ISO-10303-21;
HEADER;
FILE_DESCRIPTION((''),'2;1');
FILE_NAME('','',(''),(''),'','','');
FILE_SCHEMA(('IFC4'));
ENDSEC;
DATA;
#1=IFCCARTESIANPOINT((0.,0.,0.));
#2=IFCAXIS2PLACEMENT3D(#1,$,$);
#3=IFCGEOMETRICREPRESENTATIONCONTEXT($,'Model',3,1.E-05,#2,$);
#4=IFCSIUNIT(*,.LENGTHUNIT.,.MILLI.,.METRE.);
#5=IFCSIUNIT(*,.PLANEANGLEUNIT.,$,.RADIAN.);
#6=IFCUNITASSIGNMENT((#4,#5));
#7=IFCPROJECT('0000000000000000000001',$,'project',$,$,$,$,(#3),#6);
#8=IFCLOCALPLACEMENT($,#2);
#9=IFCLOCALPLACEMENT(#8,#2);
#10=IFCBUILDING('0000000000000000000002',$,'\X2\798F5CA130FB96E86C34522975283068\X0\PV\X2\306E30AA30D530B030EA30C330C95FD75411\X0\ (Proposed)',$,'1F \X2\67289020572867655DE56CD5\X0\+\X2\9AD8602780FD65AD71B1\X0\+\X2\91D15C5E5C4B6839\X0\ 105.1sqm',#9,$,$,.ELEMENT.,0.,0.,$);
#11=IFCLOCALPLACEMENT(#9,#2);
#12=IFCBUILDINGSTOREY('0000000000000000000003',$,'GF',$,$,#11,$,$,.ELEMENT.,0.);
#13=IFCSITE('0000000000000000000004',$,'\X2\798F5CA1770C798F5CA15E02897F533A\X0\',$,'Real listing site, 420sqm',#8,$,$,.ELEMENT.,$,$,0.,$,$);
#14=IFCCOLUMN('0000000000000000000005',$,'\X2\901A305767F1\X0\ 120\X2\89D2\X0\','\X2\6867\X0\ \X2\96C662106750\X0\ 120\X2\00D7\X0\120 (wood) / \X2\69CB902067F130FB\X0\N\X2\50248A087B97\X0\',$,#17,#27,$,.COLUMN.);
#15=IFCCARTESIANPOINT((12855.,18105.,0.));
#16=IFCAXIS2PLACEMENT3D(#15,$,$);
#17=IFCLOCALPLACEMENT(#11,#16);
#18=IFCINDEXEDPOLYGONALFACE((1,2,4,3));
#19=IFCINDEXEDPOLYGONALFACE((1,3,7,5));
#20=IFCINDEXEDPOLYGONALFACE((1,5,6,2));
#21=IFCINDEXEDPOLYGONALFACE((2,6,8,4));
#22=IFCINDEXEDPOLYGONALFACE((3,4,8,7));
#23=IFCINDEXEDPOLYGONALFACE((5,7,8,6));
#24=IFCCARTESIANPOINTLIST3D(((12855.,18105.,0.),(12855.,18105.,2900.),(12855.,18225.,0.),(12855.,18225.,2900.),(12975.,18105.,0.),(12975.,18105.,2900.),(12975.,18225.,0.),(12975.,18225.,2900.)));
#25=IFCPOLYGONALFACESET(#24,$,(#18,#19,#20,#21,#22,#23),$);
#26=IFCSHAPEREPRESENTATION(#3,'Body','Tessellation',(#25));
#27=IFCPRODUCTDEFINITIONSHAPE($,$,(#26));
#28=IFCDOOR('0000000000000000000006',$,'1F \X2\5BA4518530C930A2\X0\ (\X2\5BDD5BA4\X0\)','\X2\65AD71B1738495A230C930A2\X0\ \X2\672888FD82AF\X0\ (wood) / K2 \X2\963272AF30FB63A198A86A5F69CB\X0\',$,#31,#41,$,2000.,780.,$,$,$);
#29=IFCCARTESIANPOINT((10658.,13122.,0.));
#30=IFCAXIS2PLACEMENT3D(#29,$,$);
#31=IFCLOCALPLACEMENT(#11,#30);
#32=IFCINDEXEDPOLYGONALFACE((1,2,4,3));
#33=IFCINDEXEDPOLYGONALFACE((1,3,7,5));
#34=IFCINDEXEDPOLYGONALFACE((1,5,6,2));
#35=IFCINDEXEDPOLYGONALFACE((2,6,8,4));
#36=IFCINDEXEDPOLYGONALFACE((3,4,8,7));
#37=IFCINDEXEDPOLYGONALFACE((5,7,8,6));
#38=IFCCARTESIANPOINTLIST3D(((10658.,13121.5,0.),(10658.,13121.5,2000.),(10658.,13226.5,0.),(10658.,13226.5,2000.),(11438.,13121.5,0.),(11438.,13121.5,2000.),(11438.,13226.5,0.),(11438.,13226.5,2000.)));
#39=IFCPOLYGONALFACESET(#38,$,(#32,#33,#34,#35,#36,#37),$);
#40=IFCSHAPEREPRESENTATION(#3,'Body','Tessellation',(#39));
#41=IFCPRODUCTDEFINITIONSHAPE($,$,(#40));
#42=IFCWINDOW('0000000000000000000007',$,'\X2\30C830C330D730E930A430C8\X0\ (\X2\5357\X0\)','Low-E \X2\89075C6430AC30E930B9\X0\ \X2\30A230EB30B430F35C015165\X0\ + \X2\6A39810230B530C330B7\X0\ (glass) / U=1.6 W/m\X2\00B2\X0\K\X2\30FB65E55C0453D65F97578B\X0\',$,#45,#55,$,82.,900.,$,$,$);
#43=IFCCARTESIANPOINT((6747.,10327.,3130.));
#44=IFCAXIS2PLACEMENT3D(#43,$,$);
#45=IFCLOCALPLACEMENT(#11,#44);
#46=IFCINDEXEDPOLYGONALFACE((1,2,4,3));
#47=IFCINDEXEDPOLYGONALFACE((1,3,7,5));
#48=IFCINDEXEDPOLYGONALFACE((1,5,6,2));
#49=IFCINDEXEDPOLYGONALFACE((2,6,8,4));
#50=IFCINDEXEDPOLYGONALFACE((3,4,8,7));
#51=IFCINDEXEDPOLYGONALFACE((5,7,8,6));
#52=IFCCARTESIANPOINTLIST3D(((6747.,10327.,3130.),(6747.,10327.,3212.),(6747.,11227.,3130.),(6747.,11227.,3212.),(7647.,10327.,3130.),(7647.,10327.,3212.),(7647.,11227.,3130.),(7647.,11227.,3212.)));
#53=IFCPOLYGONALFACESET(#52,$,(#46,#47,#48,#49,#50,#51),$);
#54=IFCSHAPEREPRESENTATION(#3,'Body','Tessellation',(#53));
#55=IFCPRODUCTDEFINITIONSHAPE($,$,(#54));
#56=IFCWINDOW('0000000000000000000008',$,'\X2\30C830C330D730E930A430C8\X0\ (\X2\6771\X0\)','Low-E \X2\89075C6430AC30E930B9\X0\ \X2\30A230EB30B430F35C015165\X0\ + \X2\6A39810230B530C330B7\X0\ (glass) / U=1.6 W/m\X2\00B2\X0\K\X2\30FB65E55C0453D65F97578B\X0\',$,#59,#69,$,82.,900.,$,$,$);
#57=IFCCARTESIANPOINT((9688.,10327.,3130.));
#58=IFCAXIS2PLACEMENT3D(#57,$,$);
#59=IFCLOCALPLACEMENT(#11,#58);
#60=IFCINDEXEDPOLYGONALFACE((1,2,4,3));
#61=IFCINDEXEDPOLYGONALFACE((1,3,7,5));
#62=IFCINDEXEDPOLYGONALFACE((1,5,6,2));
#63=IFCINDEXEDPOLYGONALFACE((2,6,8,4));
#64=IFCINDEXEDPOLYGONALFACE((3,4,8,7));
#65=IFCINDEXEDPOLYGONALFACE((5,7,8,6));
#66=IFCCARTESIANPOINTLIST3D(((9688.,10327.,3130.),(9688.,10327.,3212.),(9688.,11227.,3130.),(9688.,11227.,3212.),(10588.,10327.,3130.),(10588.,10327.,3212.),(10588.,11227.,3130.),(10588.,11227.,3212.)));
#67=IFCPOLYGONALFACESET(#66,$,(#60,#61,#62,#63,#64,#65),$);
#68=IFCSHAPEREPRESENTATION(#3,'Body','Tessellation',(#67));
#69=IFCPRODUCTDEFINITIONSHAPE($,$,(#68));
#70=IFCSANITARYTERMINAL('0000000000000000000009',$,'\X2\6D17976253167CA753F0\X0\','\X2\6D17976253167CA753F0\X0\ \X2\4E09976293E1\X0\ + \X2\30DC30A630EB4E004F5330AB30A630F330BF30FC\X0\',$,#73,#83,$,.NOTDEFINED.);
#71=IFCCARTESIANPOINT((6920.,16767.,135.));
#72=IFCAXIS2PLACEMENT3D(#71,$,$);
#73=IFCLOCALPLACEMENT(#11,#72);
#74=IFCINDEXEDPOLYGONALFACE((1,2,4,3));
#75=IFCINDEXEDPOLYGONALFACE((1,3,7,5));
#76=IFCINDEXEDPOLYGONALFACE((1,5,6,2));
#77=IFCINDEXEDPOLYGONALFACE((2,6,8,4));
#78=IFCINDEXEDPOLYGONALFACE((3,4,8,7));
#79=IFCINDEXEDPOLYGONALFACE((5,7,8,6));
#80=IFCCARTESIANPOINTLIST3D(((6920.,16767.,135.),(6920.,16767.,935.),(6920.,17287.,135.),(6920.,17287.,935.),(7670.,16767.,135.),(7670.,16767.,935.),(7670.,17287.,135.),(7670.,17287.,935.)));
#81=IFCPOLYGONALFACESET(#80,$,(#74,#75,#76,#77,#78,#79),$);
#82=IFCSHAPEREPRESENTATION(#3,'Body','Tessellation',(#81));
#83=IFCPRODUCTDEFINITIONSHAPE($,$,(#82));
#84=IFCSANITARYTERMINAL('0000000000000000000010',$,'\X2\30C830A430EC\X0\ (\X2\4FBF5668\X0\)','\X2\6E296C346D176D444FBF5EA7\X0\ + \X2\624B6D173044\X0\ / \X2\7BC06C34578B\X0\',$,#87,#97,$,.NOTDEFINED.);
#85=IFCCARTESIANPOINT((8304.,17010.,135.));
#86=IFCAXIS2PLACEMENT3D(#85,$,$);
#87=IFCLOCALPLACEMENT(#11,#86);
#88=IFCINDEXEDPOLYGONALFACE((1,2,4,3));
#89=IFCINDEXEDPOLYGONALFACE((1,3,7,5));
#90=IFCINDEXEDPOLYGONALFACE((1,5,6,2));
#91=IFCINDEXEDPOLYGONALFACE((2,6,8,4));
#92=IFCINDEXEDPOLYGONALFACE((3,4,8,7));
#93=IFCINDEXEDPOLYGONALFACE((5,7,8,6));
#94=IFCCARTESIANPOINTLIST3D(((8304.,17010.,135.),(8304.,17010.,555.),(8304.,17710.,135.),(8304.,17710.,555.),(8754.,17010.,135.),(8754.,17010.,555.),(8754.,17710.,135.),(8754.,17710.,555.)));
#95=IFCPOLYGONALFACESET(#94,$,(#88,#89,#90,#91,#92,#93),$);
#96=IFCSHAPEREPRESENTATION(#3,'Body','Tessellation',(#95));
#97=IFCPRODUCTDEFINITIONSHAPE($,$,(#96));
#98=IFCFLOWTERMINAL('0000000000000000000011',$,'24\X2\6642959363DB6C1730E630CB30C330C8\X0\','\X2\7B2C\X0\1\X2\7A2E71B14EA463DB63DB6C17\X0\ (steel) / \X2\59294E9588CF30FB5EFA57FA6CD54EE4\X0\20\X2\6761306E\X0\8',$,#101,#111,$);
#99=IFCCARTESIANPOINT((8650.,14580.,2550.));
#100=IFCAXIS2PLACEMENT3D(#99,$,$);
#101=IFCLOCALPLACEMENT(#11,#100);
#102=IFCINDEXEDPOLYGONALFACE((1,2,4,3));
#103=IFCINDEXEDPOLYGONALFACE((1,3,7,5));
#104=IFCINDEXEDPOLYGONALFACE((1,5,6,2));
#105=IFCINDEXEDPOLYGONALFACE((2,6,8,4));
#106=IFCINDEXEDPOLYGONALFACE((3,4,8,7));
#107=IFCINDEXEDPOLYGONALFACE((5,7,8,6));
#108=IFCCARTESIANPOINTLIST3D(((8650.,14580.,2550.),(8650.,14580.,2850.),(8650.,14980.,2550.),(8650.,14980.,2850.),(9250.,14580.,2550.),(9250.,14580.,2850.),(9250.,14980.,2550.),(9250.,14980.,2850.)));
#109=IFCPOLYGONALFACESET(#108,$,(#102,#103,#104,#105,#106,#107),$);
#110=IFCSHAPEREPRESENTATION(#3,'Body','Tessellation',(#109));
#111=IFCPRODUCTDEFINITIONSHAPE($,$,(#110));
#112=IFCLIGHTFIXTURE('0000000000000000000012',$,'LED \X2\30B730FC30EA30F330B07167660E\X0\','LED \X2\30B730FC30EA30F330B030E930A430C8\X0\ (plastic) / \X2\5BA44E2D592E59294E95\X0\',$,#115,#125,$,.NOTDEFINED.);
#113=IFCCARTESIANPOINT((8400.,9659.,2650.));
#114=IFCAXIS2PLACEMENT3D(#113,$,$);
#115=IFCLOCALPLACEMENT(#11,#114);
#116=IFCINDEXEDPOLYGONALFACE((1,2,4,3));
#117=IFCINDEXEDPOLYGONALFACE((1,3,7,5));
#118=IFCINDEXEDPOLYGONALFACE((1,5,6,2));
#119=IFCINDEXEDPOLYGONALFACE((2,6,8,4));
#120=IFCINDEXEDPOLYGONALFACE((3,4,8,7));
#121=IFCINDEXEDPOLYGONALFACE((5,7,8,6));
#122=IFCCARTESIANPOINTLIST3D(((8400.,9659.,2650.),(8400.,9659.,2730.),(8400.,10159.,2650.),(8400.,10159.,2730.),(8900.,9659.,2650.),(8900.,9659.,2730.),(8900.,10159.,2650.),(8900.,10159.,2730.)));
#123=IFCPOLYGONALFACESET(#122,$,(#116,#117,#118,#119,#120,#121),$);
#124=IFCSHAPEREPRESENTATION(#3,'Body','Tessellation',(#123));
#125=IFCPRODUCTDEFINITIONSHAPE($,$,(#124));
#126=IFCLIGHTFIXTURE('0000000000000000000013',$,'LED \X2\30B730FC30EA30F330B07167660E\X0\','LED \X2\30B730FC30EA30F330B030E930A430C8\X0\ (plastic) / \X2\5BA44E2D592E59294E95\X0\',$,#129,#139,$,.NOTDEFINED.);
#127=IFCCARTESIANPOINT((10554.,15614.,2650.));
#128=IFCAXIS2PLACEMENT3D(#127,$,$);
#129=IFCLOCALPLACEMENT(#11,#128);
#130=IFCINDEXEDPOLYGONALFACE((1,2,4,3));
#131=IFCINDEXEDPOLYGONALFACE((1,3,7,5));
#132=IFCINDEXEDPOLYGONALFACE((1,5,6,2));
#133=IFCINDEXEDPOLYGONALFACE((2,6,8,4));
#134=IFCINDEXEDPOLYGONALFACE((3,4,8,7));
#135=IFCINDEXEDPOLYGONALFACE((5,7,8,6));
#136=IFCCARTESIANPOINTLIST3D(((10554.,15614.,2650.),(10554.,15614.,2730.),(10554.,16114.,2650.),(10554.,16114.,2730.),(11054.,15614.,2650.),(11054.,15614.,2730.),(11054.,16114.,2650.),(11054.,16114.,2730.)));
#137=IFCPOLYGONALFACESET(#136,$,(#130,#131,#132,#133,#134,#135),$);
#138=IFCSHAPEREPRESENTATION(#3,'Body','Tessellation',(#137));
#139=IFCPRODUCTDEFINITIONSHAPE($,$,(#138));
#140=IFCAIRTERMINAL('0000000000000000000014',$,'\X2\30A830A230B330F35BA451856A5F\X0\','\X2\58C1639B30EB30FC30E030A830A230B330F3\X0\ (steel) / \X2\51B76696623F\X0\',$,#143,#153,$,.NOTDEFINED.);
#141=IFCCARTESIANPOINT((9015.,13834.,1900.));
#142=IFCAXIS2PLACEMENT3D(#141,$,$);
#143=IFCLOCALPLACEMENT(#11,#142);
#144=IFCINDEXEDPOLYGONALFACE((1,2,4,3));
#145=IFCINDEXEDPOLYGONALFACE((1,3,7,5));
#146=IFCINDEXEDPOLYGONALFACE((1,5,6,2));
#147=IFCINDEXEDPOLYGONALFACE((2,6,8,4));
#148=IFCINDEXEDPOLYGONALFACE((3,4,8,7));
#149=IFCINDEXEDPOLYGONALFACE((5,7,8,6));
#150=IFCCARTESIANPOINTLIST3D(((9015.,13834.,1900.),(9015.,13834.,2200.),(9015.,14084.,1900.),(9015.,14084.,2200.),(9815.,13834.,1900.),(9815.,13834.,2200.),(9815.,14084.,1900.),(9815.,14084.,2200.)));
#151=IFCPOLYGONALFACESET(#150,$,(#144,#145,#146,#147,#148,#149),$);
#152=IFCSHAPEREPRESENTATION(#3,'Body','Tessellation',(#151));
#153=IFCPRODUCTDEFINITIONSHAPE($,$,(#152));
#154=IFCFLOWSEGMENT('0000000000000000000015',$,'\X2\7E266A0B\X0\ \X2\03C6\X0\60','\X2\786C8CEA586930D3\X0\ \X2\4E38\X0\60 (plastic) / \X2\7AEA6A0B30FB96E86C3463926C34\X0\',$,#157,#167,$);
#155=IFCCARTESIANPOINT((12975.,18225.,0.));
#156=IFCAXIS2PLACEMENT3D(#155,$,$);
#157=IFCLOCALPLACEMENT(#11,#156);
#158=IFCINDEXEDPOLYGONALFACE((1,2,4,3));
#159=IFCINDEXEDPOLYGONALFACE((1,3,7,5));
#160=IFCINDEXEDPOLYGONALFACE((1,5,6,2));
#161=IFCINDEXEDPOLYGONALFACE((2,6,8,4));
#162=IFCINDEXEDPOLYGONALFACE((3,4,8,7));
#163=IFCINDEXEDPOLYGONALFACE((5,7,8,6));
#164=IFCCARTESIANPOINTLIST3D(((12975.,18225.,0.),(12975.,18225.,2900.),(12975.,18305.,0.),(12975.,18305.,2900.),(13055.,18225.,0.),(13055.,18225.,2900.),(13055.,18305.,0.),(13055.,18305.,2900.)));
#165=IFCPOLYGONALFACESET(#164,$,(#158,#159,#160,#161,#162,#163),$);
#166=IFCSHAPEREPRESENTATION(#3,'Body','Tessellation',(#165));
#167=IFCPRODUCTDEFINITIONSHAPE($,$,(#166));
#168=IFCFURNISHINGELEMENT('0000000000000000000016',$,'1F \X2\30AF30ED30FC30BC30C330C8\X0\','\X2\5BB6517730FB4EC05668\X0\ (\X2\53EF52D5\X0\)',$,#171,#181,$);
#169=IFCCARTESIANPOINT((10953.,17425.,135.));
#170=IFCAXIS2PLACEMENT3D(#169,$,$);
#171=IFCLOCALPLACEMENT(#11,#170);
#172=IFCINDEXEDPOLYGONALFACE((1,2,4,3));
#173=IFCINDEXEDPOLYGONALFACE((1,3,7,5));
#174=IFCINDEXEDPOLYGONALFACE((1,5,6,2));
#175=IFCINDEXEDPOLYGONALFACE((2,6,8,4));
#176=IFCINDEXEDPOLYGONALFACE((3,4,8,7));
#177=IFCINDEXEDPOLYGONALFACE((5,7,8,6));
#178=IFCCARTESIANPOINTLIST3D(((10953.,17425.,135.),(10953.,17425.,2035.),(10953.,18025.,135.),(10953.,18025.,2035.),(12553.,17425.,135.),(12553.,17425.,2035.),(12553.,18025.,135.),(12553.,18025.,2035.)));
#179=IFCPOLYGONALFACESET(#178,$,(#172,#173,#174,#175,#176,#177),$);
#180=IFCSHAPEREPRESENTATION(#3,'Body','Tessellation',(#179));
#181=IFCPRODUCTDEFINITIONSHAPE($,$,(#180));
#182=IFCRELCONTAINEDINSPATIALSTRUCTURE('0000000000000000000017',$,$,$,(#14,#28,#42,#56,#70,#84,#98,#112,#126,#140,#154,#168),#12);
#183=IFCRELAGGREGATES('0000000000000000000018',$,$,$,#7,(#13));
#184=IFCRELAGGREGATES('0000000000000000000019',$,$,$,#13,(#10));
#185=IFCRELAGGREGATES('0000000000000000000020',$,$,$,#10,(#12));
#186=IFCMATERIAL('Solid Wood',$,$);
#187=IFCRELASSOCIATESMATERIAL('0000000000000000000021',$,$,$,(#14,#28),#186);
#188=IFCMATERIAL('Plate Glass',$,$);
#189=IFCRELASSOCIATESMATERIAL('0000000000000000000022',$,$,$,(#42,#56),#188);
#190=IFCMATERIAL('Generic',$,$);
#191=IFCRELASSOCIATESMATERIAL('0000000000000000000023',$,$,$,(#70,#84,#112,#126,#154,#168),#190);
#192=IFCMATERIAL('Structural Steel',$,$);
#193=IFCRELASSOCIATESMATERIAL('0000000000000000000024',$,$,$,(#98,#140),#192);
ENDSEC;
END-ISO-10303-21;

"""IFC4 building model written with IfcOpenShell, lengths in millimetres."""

from ifc_helpers import new_model, si_unit, frame, frame_2d, origin, place, context, project, spatial, rectangle, extrude, material, element, save


model = new_model("IFC4")

# Units and contexts
model_context = context("Model", 3, precision=1e-05, world=origin())
ifc_project = project(units=[si_unit("LENGTHUNIT", "METRE", prefix="MILLI"), si_unit("PLANEANGLEUNIT", "RADIAN")], contexts=[model_context])

# Site, building, storey
site_placement = place(None, origin())
site = spatial("IfcSite", under=ifc_project, at=site_placement, Name="福岡県福岡市西区", ObjectType="Real listing site, 420sqm", CompositionType="ELEMENT", RefElevation=0.0)
building_placement = place(site_placement, origin())
building = spatial("IfcBuilding", under=site, at=building_placement, Name="福岡・雨水利用とPVのオフグリッド志向 (Proposed)", ObjectType="1F 木造在来工法+高性能断熱+金属屋根 105.1sqm", CompositionType="ELEMENT", ElevationOfRefHeight=0.0, ElevationOfTerrain=0.0)
storey_placement = place(building_placement, origin())
storey = spatial("IfcBuildingStorey", under=building, at=storey_placement, Name="GF", CompositionType="ELEMENT", Elevation=0.0)

# Column
ifc_material_1 = material(Name="Solid Wood")
column_1_placement = place(storey_placement, frame((12855.0, 18105.0, 0.0)))
element("IfcColumn", 1, at=column_1_placement, inside=storey, material=ifc_material_1, Name="通し柱 120角", Description="桧 集成材 120×120 (wood) / 構造柱・N値計算", PredefinedType="COLUMN", context=model_context, shape_type="SweptSolid", body=[
    extrude(rectangle(XDim=120.0, YDim=120.0, at=frame_2d((60.0, 60.0))), frame((12855.0, 18105.0, 0.0)), (0.0, 0.0, 1.0), 2900.0),
])

# Door
door_placement = place(storey_placement, frame((10658.0, 13122.0, 0.0)))
element("IfcDoor", 2, at=door_placement, inside=storey, material=ifc_material_1, Name="1F 室内ドア (寝室)", Description="断熱玄関ドア 木製芯 (wood) / K2 防犯・採風機構", OverallHeight=2000.0, OverallWidth=780.0, context=model_context, shape_type="SweptSolid", body=[
    extrude(rectangle(XDim=780.0, YDim=105.0, at=frame_2d((390.0, 52.0))), frame((10658.0, 13122.0, 0.0)), (0.0, 0.0, 1.0), 2000.0),
])

# Windows
ifc_material_2 = material(Name="Plate Glass")
window_1_placement = place(storey_placement, frame((6747.0, 10327.0, 3130.0)))
element("IfcWindow", 3, at=window_1_placement, inside=storey, material=ifc_material_2, Name="トップライト (南)", Description="Low-E 複層ガラス アルゴン封入 + 樹脂サッシ (glass) / U=1.6 W/m²K・日射取得型", OverallHeight=82.0, OverallWidth=900.0, context=model_context, shape_type="SweptSolid", body=[
    extrude(rectangle(XDim=900.0, YDim=900.0, at=frame_2d((450.0, 450.0))), frame((6747.0, 10327.0, 3130.0)), (0.0, 0.0, 1.0), 82.0),
])
window_2_placement = place(storey_placement, frame((9688.0, 10327.0, 3130.0)))
element("IfcWindow", 4, at=window_2_placement, inside=storey, material=ifc_material_2, Name="トップライト (東)", Description="Low-E 複層ガラス アルゴン封入 + 樹脂サッシ (glass) / U=1.6 W/m²K・日射取得型", OverallHeight=82.0, OverallWidth=900.0, context=model_context, shape_type="SweptSolid", body=[
    extrude(rectangle(XDim=900.0, YDim=900.0, at=frame_2d((450.0, 450.0))), frame((9688.0, 10327.0, 3130.0)), (0.0, 0.0, 1.0), 82.0),
])

# Sanitary terminals
ifc_material_3 = material(Name="Generic")
sanitary_terminal_1_placement = place(storey_placement, frame((6920.0, 16767.0, 135.0)))
element("IfcSanitaryTerminal", 5, at=sanitary_terminal_1_placement, inside=storey, material=ifc_material_3, Name="洗面化粧台", Description="洗面化粧台 三面鏡 + ボウル一体カウンター", PredefinedType="NOTDEFINED", context=model_context, shape_type="SweptSolid", body=[
    extrude(rectangle(XDim=750.0, YDim=520.0, at=frame_2d((375.0, 260.0))), frame((6920.0, 16767.0, 135.0)), (0.0, 0.0, 1.0), 800.0),
])
sanitary_terminal_2_placement = place(storey_placement, frame((8304.0, 17010.0, 135.0)))
element("IfcSanitaryTerminal", 6, at=sanitary_terminal_2_placement, inside=storey, material=ifc_material_3, Name="トイレ (便器)", Description="温水洗浄便座 + 手洗い / 節水型", PredefinedType="NOTDEFINED", context=model_context, shape_type="SweptSolid", body=[
    extrude(rectangle(XDim=450.0, YDim=700.0, at=frame_2d((225.0, 350.0))), frame((8304.0, 17010.0, 135.0)), (0.0, 0.0, 1.0), 420.0),
])

# Flow terminal
ifc_material_4 = material(Name="Structural Steel")
flow_terminal_placement = place(storey_placement, frame((8650.0, 14580.0, 2550.0)))
element("IfcFlowTerminal", 7, at=flow_terminal_placement, inside=storey, material=ifc_material_4, Name="24時間換気ユニット", Description="第1種熱交換換気 (steel) / 天井裏・建基法令20条の8", context=model_context, shape_type="SweptSolid", body=[
    extrude(rectangle(XDim=600.0, YDim=400.0, at=frame_2d((300.0, 200.0))), frame((8650.0, 14580.0, 2550.0)), (0.0, 0.0, 1.0), 300.0),
])

# Light fixtures
light_fixture_1_placement = place(storey_placement, frame((8400.0, 9659.0, 2650.0)))
element("IfcLightFixture", 8, at=light_fixture_1_placement, inside=storey, material=ifc_material_3, Name="LED シーリング照明", Description="LED シーリングライト (plastic) / 室中央天井", PredefinedType="NOTDEFINED", context=model_context, shape_type="SweptSolid", body=[
    extrude(rectangle(XDim=500.0, YDim=500.0, at=frame_2d((250.0, 250.0))), frame((8400.0, 9659.0, 2650.0)), (0.0, 0.0, 1.0), 80.0),
])
light_fixture_2_placement = place(storey_placement, frame((10554.0, 15614.0, 2650.0)))
element("IfcLightFixture", 9, at=light_fixture_2_placement, inside=storey, material=ifc_material_3, Name="LED シーリング照明", Description="LED シーリングライト (plastic) / 室中央天井", PredefinedType="NOTDEFINED", context=model_context, shape_type="SweptSolid", body=[
    extrude(rectangle(XDim=500.0, YDim=500.0, at=frame_2d((250.0, 250.0))), frame((10554.0, 15614.0, 2650.0)), (0.0, 0.0, 1.0), 80.0),
])

# Air terminal
air_terminal_placement = place(storey_placement, frame((9015.0, 13834.0, 1900.0)))
element("IfcAirTerminal", 10, at=air_terminal_placement, inside=storey, material=ifc_material_4, Name="エアコン室内機", Description="壁掛ルームエアコン (steel) / 冷暖房", PredefinedType="NOTDEFINED", context=model_context, shape_type="SweptSolid", body=[
    extrude(rectangle(XDim=800.0, YDim=250.0, at=frame_2d((400.0, 125.0))), frame((9015.0, 13834.0, 1900.0)), (0.0, 0.0, 1.0), 300.0),
])

# Flow segment
flow_segment_placement = place(storey_placement, frame((12975.0, 18225.0, 0.0)))
element("IfcFlowSegment", 11, at=flow_segment_placement, inside=storey, material=ifc_material_3, Name="縦樋 φ60", Description="硬質塩ビ 丸60 (plastic) / 竪樋・雨水排水", context=model_context, shape_type="SweptSolid", body=[
    extrude(rectangle(XDim=80.0, YDim=80.0, at=frame_2d((40.0, 40.0))), frame((12975.0, 18225.0, 0.0)), (0.0, 0.0, 1.0), 2900.0),
])

# Furnishing element
furnishing_placement = place(storey_placement, frame((10953.0, 17425.0, 135.0)))
element("IfcFurnishingElement", 12, at=furnishing_placement, inside=storey, material=ifc_material_3, Name="1F クローゼット", Description="家具・什器 (可動)", context=model_context, shape_type="SweptSolid", body=[
    extrude(rectangle(XDim=1600.0, YDim=600.0, at=frame_2d((800.0, 300.0))), frame((10953.0, 17425.0, 135.0)), (0.0, 0.0, 1.0), 1900.0),
])

save(model, "model.ifc")
